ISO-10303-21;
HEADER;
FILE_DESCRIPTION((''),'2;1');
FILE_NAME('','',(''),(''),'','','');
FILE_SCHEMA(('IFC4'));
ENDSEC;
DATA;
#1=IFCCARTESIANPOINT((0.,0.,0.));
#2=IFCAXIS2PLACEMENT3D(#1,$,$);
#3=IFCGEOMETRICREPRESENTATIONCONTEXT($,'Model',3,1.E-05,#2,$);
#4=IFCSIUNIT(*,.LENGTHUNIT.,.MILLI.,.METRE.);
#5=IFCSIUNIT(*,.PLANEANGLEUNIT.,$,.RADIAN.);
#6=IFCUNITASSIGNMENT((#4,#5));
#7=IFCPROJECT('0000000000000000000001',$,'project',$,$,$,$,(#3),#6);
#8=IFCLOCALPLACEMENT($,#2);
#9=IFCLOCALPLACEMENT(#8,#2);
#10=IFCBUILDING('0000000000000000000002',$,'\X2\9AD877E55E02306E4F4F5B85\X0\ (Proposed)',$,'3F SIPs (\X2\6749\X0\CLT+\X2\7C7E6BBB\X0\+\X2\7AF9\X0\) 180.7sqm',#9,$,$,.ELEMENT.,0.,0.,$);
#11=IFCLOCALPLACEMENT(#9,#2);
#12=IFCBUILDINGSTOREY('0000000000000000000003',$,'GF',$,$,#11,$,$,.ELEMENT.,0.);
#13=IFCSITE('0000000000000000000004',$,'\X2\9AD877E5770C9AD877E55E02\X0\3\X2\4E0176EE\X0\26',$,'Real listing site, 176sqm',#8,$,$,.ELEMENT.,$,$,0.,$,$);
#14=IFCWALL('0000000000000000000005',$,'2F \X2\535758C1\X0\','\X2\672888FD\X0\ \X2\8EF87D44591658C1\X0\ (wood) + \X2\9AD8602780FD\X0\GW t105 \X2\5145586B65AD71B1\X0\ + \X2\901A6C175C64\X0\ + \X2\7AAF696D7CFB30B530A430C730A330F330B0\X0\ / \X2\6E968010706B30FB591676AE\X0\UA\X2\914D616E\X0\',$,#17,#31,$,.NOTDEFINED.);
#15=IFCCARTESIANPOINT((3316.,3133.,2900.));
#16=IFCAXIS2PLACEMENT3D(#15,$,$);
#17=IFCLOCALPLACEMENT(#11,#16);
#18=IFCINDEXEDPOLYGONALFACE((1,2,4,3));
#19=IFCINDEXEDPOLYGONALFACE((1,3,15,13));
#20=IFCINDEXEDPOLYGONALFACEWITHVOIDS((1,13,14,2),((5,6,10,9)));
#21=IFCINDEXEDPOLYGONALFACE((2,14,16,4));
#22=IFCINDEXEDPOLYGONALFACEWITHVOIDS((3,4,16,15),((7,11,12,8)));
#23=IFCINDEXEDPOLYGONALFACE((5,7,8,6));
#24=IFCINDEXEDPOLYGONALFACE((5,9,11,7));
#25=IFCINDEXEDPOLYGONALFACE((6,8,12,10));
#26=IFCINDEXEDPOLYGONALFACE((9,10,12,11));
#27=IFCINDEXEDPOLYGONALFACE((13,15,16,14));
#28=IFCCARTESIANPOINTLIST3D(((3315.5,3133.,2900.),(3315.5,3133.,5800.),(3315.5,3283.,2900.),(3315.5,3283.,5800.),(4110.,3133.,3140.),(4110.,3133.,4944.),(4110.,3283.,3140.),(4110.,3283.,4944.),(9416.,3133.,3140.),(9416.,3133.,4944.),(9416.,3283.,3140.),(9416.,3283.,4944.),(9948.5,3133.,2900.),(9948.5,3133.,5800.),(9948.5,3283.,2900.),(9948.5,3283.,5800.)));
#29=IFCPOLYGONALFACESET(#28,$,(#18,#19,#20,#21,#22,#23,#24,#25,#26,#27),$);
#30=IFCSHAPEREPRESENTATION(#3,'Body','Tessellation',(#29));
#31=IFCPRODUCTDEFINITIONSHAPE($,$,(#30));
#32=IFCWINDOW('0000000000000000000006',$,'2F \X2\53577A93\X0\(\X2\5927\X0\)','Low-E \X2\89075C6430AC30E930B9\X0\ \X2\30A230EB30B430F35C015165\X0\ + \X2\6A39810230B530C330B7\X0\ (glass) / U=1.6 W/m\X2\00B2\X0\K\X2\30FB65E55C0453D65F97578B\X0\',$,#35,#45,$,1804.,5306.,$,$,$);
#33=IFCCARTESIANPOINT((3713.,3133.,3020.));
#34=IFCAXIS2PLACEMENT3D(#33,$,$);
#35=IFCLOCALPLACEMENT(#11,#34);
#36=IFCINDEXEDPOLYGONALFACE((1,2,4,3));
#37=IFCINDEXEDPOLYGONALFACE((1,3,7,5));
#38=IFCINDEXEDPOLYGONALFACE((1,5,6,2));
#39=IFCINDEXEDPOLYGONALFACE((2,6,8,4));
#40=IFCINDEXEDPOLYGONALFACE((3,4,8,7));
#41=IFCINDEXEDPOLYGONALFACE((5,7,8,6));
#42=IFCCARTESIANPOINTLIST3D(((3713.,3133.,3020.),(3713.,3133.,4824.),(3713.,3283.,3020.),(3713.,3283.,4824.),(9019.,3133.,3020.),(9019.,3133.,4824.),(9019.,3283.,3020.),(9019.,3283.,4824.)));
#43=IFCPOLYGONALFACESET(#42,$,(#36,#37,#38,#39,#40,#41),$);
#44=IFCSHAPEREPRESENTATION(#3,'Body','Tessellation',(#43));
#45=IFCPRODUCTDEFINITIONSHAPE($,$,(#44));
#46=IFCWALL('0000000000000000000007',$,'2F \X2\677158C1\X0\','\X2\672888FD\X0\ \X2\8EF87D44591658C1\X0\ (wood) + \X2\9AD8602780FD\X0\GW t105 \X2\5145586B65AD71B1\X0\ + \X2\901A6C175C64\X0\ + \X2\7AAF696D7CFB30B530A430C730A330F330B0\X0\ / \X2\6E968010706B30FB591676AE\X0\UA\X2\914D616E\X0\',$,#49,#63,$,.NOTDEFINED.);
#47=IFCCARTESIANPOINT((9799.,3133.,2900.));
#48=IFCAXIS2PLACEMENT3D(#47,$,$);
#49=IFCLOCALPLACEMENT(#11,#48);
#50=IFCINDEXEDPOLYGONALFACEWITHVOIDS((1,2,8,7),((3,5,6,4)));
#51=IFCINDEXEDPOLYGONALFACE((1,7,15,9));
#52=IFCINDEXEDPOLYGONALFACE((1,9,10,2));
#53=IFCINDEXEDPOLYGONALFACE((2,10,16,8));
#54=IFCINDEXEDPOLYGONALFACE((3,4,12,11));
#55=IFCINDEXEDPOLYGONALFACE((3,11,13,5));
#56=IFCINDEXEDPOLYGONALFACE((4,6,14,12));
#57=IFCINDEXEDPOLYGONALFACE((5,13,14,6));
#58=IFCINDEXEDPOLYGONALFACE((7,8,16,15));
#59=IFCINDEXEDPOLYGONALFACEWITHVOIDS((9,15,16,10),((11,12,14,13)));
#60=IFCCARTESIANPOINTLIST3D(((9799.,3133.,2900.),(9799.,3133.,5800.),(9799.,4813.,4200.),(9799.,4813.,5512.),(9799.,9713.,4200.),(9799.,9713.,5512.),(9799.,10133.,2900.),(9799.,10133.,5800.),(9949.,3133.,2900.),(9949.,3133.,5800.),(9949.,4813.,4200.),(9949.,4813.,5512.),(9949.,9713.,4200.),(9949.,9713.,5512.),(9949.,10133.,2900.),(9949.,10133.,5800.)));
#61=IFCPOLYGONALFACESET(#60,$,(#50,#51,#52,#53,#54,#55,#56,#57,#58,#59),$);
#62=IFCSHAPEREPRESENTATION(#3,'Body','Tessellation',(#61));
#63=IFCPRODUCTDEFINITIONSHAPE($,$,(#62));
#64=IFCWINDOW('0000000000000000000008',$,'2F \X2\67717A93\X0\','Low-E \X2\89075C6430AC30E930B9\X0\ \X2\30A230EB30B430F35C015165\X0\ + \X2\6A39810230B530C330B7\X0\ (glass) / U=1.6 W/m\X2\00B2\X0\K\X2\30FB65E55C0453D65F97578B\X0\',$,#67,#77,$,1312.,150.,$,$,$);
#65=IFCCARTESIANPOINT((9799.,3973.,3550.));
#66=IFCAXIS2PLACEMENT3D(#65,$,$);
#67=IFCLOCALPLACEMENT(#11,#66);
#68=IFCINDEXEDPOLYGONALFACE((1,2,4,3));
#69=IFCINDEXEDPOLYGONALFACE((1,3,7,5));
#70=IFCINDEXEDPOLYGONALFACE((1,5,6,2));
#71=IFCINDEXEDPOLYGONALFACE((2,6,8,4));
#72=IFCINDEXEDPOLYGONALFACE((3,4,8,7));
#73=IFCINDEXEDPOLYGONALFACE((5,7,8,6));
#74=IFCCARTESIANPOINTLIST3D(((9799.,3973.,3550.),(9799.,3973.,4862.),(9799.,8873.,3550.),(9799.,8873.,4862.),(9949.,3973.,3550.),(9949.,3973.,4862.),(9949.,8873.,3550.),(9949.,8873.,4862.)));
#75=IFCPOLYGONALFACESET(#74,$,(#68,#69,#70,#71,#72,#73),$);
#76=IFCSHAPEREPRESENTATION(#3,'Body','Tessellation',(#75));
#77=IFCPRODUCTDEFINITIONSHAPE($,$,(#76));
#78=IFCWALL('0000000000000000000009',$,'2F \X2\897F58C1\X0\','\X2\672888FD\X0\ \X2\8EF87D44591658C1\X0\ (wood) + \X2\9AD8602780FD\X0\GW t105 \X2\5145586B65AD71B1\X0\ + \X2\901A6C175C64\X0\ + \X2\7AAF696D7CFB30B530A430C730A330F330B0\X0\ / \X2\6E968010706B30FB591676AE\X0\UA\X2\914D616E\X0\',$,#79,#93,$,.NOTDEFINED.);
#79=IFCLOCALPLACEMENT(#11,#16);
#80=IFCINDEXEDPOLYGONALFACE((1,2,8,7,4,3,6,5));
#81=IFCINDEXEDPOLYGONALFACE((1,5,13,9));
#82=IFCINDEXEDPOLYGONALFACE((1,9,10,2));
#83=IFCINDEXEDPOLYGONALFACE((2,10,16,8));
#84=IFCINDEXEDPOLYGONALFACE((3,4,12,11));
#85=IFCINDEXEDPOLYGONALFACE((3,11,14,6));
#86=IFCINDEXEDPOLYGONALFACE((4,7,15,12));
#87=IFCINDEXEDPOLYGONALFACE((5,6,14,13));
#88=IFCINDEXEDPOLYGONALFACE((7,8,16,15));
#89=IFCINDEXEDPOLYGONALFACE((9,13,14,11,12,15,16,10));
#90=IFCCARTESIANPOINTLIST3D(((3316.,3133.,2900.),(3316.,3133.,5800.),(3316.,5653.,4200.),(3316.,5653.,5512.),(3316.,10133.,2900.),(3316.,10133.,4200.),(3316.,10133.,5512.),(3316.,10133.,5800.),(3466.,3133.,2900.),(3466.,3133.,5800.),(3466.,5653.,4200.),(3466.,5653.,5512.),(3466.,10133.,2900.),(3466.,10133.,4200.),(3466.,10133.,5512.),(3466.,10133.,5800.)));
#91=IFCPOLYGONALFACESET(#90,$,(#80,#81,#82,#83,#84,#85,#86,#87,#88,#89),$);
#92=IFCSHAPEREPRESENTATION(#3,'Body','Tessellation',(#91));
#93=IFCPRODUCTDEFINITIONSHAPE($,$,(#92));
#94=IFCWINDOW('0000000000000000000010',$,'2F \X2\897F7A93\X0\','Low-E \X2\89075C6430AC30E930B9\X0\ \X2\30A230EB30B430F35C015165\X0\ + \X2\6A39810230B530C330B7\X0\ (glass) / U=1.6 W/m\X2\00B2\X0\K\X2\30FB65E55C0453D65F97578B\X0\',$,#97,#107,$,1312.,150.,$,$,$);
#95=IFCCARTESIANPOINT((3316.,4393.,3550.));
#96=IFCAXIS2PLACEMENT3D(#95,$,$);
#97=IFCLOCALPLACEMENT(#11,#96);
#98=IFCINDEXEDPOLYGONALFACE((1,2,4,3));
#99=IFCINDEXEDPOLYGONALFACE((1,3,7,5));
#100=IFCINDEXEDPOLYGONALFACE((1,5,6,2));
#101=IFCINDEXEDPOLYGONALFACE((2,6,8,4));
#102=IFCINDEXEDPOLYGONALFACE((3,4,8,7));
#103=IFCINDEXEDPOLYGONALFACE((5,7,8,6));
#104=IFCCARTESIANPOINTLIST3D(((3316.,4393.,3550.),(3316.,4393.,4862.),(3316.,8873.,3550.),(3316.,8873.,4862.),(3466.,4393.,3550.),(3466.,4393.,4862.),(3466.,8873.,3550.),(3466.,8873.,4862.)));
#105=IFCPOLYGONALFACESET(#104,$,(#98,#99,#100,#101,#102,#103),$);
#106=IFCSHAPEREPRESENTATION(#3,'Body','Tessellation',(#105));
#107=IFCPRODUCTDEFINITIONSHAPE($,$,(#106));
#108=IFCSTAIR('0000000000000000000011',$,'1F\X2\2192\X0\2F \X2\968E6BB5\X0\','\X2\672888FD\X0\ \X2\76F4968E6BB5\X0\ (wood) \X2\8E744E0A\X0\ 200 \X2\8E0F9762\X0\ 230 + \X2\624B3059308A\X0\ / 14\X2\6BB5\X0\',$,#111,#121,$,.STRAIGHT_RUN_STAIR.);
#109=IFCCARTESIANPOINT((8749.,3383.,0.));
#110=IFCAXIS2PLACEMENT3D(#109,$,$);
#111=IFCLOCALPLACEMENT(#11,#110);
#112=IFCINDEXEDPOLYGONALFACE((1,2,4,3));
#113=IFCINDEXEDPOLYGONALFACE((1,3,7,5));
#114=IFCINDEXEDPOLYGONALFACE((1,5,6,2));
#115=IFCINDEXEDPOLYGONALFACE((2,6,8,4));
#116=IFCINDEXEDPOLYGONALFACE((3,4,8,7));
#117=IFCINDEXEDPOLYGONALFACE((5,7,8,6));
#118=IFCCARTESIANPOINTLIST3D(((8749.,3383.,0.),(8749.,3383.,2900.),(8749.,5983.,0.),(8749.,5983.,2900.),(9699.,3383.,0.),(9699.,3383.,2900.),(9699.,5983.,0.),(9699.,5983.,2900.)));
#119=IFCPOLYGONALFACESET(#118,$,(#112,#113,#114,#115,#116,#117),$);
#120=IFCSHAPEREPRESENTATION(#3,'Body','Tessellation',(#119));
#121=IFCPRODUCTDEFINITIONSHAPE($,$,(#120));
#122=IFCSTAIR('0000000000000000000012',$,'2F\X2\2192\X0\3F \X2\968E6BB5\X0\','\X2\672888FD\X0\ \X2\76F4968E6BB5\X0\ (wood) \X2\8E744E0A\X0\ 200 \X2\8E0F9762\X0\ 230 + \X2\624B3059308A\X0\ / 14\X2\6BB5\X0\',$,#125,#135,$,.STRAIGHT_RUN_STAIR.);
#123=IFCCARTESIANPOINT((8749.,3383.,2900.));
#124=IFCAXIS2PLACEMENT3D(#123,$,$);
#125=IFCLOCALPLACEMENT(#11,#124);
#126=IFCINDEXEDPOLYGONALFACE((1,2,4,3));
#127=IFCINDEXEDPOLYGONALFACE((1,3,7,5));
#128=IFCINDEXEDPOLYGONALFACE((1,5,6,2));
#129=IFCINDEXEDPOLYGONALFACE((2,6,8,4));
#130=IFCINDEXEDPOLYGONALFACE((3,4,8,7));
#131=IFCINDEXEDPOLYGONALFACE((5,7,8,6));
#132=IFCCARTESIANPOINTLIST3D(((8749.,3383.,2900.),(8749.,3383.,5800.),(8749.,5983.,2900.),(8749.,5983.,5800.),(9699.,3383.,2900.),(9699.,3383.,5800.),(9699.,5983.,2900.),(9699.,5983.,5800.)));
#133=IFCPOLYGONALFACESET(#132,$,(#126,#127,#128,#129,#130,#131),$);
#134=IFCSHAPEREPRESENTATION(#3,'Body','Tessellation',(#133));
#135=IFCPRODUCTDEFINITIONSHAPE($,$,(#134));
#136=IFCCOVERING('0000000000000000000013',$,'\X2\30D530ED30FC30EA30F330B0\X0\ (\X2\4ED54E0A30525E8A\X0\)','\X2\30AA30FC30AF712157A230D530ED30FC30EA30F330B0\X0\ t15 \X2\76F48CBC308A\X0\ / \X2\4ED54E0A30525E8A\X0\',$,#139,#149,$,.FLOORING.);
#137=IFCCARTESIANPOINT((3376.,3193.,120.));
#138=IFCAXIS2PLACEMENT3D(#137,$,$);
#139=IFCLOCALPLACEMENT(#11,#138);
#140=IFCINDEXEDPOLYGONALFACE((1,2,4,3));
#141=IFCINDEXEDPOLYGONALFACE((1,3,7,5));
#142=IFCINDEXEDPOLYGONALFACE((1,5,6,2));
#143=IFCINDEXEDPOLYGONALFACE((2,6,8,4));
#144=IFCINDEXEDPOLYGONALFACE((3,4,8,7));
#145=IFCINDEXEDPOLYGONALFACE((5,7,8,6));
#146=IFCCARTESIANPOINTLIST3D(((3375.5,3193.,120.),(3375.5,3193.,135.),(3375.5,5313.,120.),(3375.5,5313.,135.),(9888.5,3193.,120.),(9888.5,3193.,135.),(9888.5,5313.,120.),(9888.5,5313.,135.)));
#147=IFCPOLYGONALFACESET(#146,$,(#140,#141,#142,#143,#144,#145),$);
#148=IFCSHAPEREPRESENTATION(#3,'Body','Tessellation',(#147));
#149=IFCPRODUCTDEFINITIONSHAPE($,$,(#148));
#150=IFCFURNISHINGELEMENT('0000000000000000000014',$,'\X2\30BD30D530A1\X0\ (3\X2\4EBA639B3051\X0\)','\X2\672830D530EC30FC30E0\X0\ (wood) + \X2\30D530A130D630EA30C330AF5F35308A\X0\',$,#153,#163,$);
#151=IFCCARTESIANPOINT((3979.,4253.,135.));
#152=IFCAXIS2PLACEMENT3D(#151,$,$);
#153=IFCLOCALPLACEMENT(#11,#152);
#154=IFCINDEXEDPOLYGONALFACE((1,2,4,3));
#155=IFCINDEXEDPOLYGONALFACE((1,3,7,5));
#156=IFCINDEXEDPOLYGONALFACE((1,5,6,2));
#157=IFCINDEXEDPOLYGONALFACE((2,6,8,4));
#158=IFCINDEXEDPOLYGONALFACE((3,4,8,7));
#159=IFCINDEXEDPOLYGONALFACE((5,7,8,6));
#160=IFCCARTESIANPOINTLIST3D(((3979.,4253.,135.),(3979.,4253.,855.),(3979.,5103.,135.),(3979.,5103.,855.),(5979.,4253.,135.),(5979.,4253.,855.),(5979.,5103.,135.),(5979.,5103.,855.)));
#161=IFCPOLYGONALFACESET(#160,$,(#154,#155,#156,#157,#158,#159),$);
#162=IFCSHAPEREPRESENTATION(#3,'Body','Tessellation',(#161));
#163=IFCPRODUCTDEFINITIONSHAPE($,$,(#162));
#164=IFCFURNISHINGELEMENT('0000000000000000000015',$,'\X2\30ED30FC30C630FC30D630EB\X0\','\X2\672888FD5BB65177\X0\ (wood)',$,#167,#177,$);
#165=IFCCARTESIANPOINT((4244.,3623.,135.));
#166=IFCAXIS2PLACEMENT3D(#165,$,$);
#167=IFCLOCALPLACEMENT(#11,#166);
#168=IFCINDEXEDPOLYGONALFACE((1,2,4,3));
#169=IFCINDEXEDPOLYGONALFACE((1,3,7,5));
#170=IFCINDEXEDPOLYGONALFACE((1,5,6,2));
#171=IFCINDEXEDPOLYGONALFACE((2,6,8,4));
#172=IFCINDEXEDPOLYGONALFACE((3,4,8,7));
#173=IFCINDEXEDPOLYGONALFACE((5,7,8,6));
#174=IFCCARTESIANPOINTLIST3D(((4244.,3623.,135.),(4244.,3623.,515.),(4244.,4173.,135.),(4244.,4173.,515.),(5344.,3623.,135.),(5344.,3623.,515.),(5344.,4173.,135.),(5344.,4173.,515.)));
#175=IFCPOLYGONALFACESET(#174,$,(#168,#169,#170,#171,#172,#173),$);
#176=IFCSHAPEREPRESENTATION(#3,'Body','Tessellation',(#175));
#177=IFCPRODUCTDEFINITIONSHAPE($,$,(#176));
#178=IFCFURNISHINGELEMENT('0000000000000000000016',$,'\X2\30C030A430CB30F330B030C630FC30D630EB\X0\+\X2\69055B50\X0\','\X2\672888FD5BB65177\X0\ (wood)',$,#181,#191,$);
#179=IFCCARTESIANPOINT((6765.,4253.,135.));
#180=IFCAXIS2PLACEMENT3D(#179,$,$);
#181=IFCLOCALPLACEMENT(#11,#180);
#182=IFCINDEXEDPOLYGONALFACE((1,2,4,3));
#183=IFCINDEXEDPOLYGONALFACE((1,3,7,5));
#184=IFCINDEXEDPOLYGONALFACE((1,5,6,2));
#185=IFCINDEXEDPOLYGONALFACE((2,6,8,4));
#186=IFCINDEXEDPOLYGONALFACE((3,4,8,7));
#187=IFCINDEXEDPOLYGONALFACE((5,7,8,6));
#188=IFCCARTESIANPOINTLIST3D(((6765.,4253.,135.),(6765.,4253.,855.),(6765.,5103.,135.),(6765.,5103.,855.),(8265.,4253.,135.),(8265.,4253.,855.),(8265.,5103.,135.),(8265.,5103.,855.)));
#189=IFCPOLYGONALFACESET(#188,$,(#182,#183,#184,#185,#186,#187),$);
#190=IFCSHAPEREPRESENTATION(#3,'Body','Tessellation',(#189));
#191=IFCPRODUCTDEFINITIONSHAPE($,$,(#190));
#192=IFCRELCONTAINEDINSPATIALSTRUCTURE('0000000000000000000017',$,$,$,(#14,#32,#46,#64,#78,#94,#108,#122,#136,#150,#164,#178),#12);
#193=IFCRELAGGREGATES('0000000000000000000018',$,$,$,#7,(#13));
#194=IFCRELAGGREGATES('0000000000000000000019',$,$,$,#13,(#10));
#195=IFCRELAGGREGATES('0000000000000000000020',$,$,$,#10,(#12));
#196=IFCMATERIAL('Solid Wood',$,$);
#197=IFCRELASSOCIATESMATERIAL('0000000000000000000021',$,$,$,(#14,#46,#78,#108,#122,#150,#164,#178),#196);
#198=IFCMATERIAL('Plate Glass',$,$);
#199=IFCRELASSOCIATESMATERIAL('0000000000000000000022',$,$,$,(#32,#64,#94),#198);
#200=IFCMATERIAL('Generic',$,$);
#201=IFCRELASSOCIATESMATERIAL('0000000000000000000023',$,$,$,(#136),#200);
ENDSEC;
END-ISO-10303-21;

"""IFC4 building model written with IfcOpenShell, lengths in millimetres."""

from ifc_helpers import new_model, si_unit, frame, frame_2d, origin, place, context, project, spatial, rectangle, extrude, material, element, fill, save


model = new_model("IFC4")

# Units and contexts
model_context = context("Model", 3, precision=1e-05, world=origin())
ifc_project = project(units=[si_unit("LENGTHUNIT", "METRE", prefix="MILLI"), si_unit("PLANEANGLEUNIT", "RADIAN")], contexts=[model_context])

# Site, building, storey
site_placement = place(None, origin())
site = spatial("IfcSite", under=ifc_project, at=site_placement, Name="高知県高知市3丁目26", ObjectType="Real listing site, 176sqm", CompositionType="ELEMENT", RefElevation=0.0)
building_placement = place(site_placement, origin())
building = spatial("IfcBuilding", under=site, at=building_placement, Name="高知市の住宅 (Proposed)", ObjectType="3F SIPs (杉CLT+籾殻+竹) 180.7sqm", CompositionType="ELEMENT", ElevationOfRefHeight=0.0, ElevationOfTerrain=0.0)
storey_placement = place(building_placement, origin())
storey = spatial("IfcBuildingStorey", under=building, at=storey_placement, Name="GF", CompositionType="ELEMENT", Elevation=0.0)

# Shared definitions
ifc_material_1 = material(Name="Solid Wood")
ifc_material_2 = material(Name="Generic")

# Shared definitions
ifc_material_3 = material(Name="Plate Glass")

# Walls, openings, windows
wall_1_placement = place(storey_placement, frame((3316.0, 3133.0, 2900.0)))
wall_1 = element("IfcWall", 1, at=wall_1_placement, inside=storey, material=ifc_material_1, Name="2F 南壁", Description="木製 軸組外壁 (wood) + 高性能GW t105 充填断熱 + 通気層 + 窯業系サイディング / 準耐火・外皮UA配慮", PredefinedType="NOTDEFINED", context=model_context, shape_type="SweptSolid", body=[
    extrude(rectangle(XDim=6633.0, YDim=150.0, at=frame_2d((3316.0, 75.0))), frame((3316.0, 3133.0, 2900.0)), (0.0, 0.0, 1.0), 2900.0),
])
opening_1_placement = place(storey_placement, frame((3713.0, 3133.0, 3020.0)))
opening_1 = element("IfcOpeningElement", 2, at=opening_1_placement, cuts=wall_1, PredefinedType="NOTDEFINED", context=model_context, shape_type="SweptSolid", body=[
    extrude(rectangle(XDim=5306.0, YDim=150.0, at=frame_2d((2653.0, 75.0))), frame((3713.0, 3133.0, 3020.0)), (0.0, 0.0, 1.0), 1804.0),
])
window_1_placement = place(storey_placement, frame((3713.0, 3133.0, 3020.0)))
window_1 = element("IfcWindow", 3, at=window_1_placement, inside=storey, material=ifc_material_3, Name="2F 南窓(大)", Description="Low-E 複層ガラス アルゴン封入 + 樹脂サッシ (glass) / U=1.6 W/m²K・日射取得型", OverallHeight=1804.0, OverallWidth=5306.0, context=model_context, shape_type="SweptSolid", body=[
    extrude(rectangle(XDim=5306.0, YDim=150.0, at=frame_2d((2653.0, 75.0))), frame((3713.0, 3133.0, 3020.0)), (0.0, 0.0, 1.0), 1804.0),
])
fill(opening_1, window_1)
wall_2_placement = place(storey_placement, frame((9799.0, 3133.0, 2900.0)))
wall_2 = element("IfcWall", 4, at=wall_2_placement, inside=storey, material=ifc_material_1, Name="2F 東壁", Description="木製 軸組外壁 (wood) + 高性能GW t105 充填断熱 + 通気層 + 窯業系サイディング / 準耐火・外皮UA配慮", PredefinedType="NOTDEFINED", context=model_context, shape_type="SweptSolid", body=[
    extrude(rectangle(XDim=150.0, YDim=7000.0, at=frame_2d((75.0, 3500.0))), frame((9799.0, 3133.0, 2900.0)), (0.0, 0.0, 1.0), 2900.0),
])
opening_2_placement = place(storey_placement, frame((9799.0, 3973.0, 3550.0)))
opening_2 = element("IfcOpeningElement", 5, at=opening_2_placement, cuts=wall_2, PredefinedType="NOTDEFINED", context=model_context, shape_type="SweptSolid", body=[
    extrude(rectangle(XDim=150.0, YDim=4900.0, at=frame_2d((75.0, 2450.0))), frame((9799.0, 3973.0, 3550.0)), (0.0, 0.0, 1.0), 1312.0),
])
window_2_placement = place(storey_placement, frame((9799.0, 3973.0, 3550.0)))
window_2 = element("IfcWindow", 6, at=window_2_placement, inside=storey, material=ifc_material_3, Name="2F 東窓", Description="Low-E 複層ガラス アルゴン封入 + 樹脂サッシ (glass) / U=1.6 W/m²K・日射取得型", OverallHeight=1312.0, OverallWidth=150.0, context=model_context, shape_type="SweptSolid", body=[
    extrude(rectangle(XDim=150.0, YDim=4900.0, at=frame_2d((75.0, 2450.0))), frame((9799.0, 3973.0, 3550.0)), (0.0, 0.0, 1.0), 1312.0),
])
fill(opening_2, window_2)
wall_3_placement = place(storey_placement, frame((3316.0, 3133.0, 2900.0)))
wall_3 = element("IfcWall", 7, at=wall_3_placement, inside=storey, material=ifc_material_1, Name="2F 西壁", Description="木製 軸組外壁 (wood) + 高性能GW t105 充填断熱 + 通気層 + 窯業系サイディング / 準耐火・外皮UA配慮", PredefinedType="NOTDEFINED", context=model_context, shape_type="SweptSolid", body=[
    extrude(rectangle(XDim=150.0, YDim=7000.0, at=frame_2d((75.0, 3500.0))), frame((3316.0, 3133.0, 2900.0)), (0.0, 0.0, 1.0), 2900.0),
])
opening_3_placement = place(storey_placement, frame((3316.0, 4393.0, 3550.0)))
opening_3 = element("IfcOpeningElement", 8, at=opening_3_placement, cuts=wall_3, PredefinedType="NOTDEFINED", context=model_context, shape_type="SweptSolid", body=[
    extrude(rectangle(XDim=150.0, YDim=4480.0, at=frame_2d((75.0, 2240.0))), frame((3316.0, 4393.0, 3550.0)), (0.0, 0.0, 1.0), 1312.0),
])
window_3_placement = place(storey_placement, frame((3316.0, 4393.0, 3550.0)))
window_3 = element("IfcWindow", 9, at=window_3_placement, inside=storey, material=ifc_material_3, Name="2F 西窓", Description="Low-E 複層ガラス アルゴン封入 + 樹脂サッシ (glass) / U=1.6 W/m²K・日射取得型", OverallHeight=1312.0, OverallWidth=150.0, context=model_context, shape_type="SweptSolid", body=[
    extrude(rectangle(XDim=150.0, YDim=4480.0, at=frame_2d((75.0, 2240.0))), frame((3316.0, 4393.0, 3550.0)), (0.0, 0.0, 1.0), 1312.0),
])
fill(opening_3, window_3)

# Stairs
stair_1_placement = place(storey_placement, frame((8749.0, 3383.0, 0.0)))
element("IfcStair", 10, at=stair_1_placement, inside=storey, material=ifc_material_1, Name="1F→2F 階段", Description="木製 直階段 (wood) 蹴上 200 踏面 230 + 手すり / 14段", PredefinedType="STRAIGHT_RUN_STAIR", context=model_context, shape_type="SweptSolid", body=[
    extrude(rectangle(XDim=950.0, YDim=2600.0, at=frame_2d((475.0, 1300.0))), frame((8749.0, 3383.0, 0.0)), (0.0, 0.0, 1.0), 2900.0),
])
stair_2_placement = place(storey_placement, frame((8749.0, 3383.0, 2900.0)))
element("IfcStair", 11, at=stair_2_placement, inside=storey, material=ifc_material_1, Name="2F→3F 階段", Description="木製 直階段 (wood) 蹴上 200 踏面 230 + 手すり / 14段", PredefinedType="STRAIGHT_RUN_STAIR", context=model_context, shape_type="SweptSolid", body=[
    extrude(rectangle(XDim=950.0, YDim=2600.0, at=frame_2d((475.0, 1300.0))), frame((8749.0, 3383.0, 2900.0)), (0.0, 0.0, 1.0), 2900.0),
])

# Covering
covering_placement = place(storey_placement, frame((3376.0, 3193.0, 120.0)))
element("IfcCovering", 12, at=covering_placement, inside=storey, material=ifc_material_2, Name="フローリング (仕上げ床)", Description="オーク無垢フローリング t15 直貼り / 仕上げ床", PredefinedType="FLOORING", context=model_context, shape_type="SweptSolid", body=[
    extrude(rectangle(XDim=6513.0, YDim=2120.0, at=frame_2d((3256.0, 1060.0))), frame((3376.0, 3193.0, 120.0)), (0.0, 0.0, 1.0), 15.0),
])

# Furnishing elements
furnishing_1_placement = place(storey_placement, frame((3979.0, 4253.0, 135.0)))
element("IfcFurnishingElement", 13, at=furnishing_1_placement, inside=storey, material=ifc_material_1, Name="ソファ (3人掛け)", Description="木フレーム (wood) + ファブリック張り", context=model_context, shape_type="SweptSolid", body=[
    extrude(rectangle(XDim=2000.0, YDim=850.0, at=frame_2d((1000.0, 425.0))), frame((3979.0, 4253.0, 135.0)), (0.0, 0.0, 1.0), 720.0),
])
furnishing_2_placement = place(storey_placement, frame((4244.0, 3623.0, 135.0)))
element("IfcFurnishingElement", 14, at=furnishing_2_placement, inside=storey, material=ifc_material_1, Name="ローテーブル", Description="木製家具 (wood)", context=model_context, shape_type="SweptSolid", body=[
    extrude(rectangle(XDim=1100.0, YDim=550.0, at=frame_2d((550.0, 275.0))), frame((4244.0, 3623.0, 135.0)), (0.0, 0.0, 1.0), 380.0),
])
furnishing_3_placement = place(storey_placement, frame((6765.0, 4253.0, 135.0)))
element("IfcFurnishingElement", 15, at=furnishing_3_placement, inside=storey, material=ifc_material_1, Name="ダイニングテーブル+椅子", Description="木製家具 (wood)", context=model_context, shape_type="SweptSolid", body=[
    extrude(rectangle(XDim=1500.0, YDim=850.0, at=frame_2d((750.0, 425.0))), frame((6765.0, 4253.0, 135.0)), (0.0, 0.0, 1.0), 720.0),
])

save(model, "model.ifc")
